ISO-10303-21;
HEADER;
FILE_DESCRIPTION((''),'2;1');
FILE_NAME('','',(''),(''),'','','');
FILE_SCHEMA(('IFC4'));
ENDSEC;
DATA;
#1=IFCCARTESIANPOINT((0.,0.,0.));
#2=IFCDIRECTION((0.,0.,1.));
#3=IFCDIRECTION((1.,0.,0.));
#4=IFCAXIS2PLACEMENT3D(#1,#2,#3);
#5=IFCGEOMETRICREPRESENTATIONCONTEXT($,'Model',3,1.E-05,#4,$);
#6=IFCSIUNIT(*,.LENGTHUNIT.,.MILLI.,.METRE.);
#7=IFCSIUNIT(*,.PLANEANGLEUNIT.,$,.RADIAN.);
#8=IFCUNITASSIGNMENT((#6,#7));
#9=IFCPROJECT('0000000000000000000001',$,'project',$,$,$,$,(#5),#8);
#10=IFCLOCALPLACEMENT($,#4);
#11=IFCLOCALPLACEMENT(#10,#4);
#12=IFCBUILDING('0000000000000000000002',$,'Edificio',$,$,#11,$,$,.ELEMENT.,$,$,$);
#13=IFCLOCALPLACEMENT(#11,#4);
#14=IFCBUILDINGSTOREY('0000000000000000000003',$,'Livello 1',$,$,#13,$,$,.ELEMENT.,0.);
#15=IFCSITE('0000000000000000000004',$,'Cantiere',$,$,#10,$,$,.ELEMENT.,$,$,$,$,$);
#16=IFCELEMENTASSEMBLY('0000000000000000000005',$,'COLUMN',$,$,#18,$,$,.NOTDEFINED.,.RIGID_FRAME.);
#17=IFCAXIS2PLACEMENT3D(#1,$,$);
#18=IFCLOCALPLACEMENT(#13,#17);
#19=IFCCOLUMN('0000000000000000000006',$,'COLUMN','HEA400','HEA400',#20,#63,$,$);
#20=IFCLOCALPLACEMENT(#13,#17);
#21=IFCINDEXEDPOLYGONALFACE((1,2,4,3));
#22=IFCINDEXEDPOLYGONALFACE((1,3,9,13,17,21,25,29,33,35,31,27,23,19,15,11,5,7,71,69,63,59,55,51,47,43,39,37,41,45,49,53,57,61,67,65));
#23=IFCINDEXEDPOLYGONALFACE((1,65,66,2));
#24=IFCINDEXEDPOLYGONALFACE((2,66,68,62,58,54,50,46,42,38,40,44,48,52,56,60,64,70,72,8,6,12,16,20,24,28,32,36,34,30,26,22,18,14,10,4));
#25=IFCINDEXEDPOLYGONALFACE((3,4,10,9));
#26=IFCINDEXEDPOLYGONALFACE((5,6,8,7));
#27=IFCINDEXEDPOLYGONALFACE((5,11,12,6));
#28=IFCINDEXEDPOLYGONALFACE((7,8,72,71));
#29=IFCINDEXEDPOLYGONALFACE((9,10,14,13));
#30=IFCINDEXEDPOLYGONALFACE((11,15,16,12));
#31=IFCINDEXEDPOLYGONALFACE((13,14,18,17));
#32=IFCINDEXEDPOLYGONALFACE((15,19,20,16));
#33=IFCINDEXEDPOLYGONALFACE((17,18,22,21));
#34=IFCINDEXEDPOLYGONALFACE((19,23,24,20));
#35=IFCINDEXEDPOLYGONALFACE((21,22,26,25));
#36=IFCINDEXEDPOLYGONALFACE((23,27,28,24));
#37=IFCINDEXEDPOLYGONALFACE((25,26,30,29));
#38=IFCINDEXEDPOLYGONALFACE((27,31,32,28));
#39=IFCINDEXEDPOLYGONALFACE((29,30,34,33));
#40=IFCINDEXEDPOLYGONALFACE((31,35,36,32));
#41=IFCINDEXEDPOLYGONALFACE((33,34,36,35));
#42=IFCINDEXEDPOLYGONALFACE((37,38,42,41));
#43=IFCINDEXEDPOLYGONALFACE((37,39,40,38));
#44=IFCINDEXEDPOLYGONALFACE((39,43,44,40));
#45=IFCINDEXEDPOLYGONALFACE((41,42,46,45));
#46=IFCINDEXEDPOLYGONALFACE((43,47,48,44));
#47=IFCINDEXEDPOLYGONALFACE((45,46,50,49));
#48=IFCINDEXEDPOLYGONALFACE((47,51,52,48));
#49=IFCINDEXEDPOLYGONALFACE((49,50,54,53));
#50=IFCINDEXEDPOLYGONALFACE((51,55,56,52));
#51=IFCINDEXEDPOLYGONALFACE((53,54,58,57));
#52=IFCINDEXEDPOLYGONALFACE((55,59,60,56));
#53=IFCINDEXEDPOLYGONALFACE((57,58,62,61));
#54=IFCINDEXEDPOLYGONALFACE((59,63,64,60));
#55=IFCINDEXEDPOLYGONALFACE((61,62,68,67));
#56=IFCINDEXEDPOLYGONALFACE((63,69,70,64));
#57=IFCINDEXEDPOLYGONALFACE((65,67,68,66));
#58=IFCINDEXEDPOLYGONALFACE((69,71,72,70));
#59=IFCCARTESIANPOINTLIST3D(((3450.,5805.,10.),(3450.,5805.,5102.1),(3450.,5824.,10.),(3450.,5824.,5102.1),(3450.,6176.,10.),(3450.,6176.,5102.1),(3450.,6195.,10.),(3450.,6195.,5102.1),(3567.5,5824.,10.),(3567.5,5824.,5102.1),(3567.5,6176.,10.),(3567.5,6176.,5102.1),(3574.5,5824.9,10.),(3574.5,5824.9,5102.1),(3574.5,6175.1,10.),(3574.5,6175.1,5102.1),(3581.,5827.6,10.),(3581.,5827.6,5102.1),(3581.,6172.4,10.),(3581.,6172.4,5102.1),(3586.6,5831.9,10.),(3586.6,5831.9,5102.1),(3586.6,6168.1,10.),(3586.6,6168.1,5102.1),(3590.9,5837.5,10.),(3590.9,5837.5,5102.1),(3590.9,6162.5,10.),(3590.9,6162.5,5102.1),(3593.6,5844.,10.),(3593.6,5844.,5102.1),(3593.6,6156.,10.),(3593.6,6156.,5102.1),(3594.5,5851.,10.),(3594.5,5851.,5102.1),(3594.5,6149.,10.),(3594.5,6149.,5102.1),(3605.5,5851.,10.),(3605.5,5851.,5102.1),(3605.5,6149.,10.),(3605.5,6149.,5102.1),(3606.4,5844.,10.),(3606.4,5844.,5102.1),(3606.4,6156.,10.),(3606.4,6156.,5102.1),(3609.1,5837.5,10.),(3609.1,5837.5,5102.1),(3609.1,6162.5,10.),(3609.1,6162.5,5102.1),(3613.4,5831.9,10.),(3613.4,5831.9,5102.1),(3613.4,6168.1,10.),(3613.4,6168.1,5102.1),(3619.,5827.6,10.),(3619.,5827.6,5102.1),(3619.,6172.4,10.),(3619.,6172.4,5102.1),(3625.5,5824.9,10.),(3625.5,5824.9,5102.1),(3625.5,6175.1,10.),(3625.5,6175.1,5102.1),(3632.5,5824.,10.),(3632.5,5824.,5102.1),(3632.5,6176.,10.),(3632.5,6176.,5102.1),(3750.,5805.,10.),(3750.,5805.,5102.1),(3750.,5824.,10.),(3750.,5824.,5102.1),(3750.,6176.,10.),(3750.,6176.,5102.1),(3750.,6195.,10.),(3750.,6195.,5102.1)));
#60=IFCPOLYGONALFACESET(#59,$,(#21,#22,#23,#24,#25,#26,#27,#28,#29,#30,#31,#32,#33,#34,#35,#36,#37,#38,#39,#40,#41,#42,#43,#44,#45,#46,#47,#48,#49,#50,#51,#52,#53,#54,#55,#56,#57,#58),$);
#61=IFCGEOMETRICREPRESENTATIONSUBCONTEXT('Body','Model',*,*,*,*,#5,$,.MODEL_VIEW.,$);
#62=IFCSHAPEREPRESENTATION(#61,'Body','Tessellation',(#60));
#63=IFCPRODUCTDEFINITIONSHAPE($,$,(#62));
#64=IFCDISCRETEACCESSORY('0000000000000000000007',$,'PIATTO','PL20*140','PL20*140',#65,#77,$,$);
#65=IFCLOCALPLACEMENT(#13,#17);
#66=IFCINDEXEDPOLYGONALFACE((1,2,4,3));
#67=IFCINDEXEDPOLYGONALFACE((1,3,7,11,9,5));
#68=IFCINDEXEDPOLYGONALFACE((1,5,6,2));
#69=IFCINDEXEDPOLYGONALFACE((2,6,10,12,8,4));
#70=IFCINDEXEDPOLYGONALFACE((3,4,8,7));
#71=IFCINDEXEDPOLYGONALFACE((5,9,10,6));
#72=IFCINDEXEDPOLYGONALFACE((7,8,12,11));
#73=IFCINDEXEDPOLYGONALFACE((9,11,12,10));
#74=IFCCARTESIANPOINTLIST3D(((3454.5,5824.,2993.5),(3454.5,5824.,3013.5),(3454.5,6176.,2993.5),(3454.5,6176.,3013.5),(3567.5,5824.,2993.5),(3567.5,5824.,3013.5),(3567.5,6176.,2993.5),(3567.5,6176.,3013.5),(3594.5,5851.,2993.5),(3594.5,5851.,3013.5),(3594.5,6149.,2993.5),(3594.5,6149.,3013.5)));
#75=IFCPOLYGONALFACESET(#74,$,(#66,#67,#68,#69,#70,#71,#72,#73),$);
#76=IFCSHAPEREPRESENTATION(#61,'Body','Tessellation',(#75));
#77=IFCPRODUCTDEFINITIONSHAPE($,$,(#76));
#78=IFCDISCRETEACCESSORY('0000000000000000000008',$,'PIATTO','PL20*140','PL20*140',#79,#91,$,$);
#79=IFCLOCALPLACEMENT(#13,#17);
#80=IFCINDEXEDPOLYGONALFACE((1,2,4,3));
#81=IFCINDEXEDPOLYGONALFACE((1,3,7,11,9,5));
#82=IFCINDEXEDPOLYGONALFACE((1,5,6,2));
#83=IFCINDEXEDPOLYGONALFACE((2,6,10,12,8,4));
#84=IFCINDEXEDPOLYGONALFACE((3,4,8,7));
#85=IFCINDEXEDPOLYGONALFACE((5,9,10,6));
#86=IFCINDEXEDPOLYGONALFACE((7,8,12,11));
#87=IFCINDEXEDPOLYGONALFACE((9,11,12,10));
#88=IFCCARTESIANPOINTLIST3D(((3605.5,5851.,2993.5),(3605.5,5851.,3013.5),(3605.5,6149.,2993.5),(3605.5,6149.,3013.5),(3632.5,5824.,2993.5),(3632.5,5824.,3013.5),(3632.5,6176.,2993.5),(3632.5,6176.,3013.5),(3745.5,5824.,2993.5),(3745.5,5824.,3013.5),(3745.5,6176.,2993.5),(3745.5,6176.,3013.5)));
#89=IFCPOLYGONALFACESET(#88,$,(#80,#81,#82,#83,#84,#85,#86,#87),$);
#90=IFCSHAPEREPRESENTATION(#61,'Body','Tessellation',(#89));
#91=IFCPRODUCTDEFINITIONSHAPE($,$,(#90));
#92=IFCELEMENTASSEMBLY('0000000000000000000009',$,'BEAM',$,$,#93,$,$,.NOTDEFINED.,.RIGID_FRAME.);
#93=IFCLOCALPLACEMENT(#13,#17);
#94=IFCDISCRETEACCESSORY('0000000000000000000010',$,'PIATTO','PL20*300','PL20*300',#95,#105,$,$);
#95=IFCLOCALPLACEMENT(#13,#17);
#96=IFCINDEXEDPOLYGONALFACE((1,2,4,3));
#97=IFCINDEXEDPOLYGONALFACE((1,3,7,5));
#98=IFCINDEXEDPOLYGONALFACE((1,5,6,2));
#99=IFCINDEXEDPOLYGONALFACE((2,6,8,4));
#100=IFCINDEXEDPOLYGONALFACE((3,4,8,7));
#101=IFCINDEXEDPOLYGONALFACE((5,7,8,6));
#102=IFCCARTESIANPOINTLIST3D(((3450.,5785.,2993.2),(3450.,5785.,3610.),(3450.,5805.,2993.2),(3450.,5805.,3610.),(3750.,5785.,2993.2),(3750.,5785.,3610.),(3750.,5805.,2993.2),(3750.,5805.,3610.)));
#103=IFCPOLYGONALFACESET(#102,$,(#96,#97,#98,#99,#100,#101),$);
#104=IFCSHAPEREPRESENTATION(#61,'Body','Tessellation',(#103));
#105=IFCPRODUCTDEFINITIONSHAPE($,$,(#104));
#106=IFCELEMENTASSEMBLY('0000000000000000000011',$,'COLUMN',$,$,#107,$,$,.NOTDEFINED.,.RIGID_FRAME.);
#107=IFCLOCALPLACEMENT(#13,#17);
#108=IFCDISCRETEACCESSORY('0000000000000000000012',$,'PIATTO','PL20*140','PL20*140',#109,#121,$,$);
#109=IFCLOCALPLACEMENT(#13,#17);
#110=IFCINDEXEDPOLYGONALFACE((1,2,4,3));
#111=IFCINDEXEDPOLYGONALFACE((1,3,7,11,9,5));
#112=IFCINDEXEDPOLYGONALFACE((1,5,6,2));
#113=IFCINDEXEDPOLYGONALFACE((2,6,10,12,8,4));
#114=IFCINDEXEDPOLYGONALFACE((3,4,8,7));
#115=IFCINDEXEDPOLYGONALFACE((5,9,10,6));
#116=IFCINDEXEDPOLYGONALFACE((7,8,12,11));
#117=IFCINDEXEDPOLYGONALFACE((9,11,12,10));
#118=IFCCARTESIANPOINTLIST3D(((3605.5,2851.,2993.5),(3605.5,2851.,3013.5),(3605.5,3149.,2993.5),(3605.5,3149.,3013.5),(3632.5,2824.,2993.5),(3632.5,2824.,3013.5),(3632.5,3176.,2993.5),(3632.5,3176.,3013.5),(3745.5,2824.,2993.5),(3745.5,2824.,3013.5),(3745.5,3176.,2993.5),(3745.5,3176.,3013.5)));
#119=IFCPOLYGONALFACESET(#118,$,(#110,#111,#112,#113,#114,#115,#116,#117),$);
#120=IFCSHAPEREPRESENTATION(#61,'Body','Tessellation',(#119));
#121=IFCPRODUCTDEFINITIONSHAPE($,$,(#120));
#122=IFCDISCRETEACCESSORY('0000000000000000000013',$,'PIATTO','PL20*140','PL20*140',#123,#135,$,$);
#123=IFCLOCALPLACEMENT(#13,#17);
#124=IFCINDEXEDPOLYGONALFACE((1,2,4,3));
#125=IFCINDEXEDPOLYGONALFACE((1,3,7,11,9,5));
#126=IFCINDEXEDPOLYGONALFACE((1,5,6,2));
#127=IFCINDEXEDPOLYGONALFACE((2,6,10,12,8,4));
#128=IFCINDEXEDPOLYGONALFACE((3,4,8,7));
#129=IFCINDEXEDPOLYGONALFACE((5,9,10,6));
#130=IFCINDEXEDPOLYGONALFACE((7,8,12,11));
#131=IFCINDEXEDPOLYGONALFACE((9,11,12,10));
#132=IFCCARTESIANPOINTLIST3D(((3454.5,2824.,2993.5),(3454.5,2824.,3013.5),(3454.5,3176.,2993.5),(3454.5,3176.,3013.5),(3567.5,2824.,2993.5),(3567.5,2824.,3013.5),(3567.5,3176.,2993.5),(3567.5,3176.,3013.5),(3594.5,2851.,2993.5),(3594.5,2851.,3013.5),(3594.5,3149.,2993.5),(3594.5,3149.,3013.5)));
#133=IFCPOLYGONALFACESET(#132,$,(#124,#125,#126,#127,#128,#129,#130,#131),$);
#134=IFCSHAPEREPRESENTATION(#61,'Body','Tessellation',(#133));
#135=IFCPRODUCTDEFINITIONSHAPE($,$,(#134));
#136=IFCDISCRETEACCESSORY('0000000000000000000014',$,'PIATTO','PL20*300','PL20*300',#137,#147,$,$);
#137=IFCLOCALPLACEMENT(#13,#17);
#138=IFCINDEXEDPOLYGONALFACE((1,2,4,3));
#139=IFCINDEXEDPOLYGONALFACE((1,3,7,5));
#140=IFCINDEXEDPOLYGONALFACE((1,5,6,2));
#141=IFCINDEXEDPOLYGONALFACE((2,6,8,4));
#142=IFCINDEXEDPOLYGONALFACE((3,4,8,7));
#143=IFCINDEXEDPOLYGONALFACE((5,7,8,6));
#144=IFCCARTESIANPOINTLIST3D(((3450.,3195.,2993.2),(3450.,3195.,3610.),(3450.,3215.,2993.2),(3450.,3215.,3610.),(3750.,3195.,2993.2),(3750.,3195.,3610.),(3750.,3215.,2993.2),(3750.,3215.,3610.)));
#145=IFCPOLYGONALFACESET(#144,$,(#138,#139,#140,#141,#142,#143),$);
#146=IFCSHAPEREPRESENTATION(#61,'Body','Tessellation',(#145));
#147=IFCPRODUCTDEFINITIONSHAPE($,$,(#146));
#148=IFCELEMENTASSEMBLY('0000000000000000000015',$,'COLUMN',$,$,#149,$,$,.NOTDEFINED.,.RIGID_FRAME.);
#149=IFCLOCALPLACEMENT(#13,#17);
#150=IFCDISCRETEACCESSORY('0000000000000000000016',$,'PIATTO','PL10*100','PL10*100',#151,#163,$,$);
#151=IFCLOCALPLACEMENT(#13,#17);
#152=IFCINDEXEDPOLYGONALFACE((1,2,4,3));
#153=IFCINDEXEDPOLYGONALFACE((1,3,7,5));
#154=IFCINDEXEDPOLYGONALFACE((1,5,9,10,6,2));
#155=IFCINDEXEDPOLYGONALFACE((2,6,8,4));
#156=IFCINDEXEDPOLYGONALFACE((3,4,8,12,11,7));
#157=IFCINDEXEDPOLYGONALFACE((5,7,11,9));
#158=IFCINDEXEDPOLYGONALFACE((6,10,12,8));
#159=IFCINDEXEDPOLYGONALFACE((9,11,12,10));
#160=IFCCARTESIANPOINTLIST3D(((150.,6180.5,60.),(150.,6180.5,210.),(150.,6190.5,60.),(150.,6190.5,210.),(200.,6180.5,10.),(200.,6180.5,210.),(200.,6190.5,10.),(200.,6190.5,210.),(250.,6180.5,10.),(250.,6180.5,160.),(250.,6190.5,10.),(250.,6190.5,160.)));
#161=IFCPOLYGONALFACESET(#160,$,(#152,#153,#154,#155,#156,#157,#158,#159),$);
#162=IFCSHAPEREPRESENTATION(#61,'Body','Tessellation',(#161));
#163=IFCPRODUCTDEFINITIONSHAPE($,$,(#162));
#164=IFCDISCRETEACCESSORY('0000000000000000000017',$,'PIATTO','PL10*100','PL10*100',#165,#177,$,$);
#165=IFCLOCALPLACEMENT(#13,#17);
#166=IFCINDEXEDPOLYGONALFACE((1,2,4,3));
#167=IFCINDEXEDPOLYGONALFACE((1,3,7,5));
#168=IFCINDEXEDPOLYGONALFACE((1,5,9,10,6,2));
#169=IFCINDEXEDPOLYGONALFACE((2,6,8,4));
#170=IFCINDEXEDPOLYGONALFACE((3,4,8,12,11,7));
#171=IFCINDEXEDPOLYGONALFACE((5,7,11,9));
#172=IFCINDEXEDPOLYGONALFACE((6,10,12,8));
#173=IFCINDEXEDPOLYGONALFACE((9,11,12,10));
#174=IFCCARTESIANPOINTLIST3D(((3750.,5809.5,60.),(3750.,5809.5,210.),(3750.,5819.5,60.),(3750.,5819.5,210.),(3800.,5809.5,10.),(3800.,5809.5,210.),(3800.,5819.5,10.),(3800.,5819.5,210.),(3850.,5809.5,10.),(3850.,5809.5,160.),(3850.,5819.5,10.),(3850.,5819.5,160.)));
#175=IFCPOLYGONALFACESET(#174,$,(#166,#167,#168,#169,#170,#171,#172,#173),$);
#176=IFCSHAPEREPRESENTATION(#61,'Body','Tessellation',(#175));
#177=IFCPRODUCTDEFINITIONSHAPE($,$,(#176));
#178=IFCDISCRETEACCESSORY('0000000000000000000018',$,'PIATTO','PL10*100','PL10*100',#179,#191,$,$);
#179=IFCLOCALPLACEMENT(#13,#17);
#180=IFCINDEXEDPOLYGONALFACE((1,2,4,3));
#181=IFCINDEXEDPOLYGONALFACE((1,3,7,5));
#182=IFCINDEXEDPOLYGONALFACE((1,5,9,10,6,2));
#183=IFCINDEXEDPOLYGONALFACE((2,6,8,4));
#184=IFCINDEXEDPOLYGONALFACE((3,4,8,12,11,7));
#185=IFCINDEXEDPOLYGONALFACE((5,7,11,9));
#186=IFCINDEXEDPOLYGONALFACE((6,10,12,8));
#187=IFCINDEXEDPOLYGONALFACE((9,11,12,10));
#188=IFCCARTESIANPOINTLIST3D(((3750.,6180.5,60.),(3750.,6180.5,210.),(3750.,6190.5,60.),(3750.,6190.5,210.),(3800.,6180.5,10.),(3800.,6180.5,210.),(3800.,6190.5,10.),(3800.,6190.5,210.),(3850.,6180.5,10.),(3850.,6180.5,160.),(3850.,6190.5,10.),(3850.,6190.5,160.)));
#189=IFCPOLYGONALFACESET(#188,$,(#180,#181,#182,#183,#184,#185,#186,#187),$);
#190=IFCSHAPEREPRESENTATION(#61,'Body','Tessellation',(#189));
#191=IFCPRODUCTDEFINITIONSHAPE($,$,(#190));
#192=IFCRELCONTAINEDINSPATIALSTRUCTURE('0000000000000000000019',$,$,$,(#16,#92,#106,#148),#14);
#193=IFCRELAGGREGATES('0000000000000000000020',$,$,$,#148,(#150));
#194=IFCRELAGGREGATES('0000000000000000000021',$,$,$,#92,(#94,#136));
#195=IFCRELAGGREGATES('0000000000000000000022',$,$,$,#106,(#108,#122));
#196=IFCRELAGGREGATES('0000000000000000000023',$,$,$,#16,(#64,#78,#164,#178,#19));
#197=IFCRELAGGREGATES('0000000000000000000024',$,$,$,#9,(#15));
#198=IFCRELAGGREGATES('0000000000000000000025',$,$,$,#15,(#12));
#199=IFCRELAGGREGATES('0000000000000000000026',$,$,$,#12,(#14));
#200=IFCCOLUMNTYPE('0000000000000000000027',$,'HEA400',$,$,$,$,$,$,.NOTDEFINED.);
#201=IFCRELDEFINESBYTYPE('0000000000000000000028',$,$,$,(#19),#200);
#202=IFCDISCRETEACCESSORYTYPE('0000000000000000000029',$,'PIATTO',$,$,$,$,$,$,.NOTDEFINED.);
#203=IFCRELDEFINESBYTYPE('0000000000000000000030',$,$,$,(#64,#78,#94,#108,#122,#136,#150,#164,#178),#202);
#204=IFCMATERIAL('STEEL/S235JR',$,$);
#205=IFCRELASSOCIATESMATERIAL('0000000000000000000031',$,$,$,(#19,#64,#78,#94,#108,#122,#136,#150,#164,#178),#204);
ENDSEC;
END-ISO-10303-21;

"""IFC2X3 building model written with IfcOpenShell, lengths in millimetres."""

from ifc_helpers import new_model, si_unit, frame, origin_with_axes, origin_2d_with_axis, place, context, subcontext, project, spatial, polyline, i_section, outline, extrude, clip, halfspace, material, type_object, element, aggregate, save


model = new_model("IFC2X3")

# Units and contexts
model_context = context("Model", 3, precision=1e-05, world=origin_with_axes())
body_context = subcontext(model_context, "Body", "Model", "MODEL_VIEW")
ifc_project = project(units=[si_unit("LENGTHUNIT", "METRE", prefix="MILLI"), si_unit("PLANEANGLEUNIT", "RADIAN")], contexts=[model_context])

# Site, building, storey
site_placement = place(None, origin_with_axes())
site = spatial("IfcSite", under=ifc_project, at=site_placement, Name="Cantiere", CompositionType="ELEMENT")
building_placement = place(site_placement, origin_with_axes())
building = spatial("IfcBuilding", under=site, at=building_placement, Name="Edificio", CompositionType="ELEMENT")
storey_placement = place(building_placement, origin_with_axes())
storey = spatial("IfcBuildingStorey", under=building, at=storey_placement, Name="Livello 1", CompositionType="ELEMENT", Elevation=0.0)

# Element assembly, column, discrete accessories
assembly_1_placement = place(storey_placement, origin_with_axes())
assembly_1 = element("IfcElementAssembly", 1, at=assembly_1_placement, inside=storey, Name="COLUMN", AssemblyPlace="NOTDEFINED", PredefinedType="RIGID_FRAME")
ifc_material_1 = material(Name="STEEL/S235JR")
column_type = type_object("IfcColumnType", Name="HEA400", PredefinedType="NOTDEFINED")
column_placement = place(assembly_1_placement, frame((3600.0, 6000.0, 0.0), z_axis=(0.0, 0.0, 1.0), x_axis=(0.0, 1.0, 0.0)))
column = element("IfcColumn", 2, at=column_placement, type_object=column_type, material=ifc_material_1, Name="COLUMN", Description="HEA400", ObjectType="HEA400", context=body_context, shape_type="Clipping", body=[
    clip(clip(extrude(i_section(OverallWidth=300.0, OverallDepth=390.0, WebThickness=11.0, FlangeThickness=19.0, FilletRadius=27.0, at=origin_2d_with_axis()), frame((0.0, 0.0, 5102.1), z_axis=(0.0, 0.0, -1.0), x_axis=(0.0, 1.0, 0.0)), (0.0, 0.0, 1.0), 5092.1), halfspace(frame((-1000.0, 0.0, 5102.1), z_axis=(0.0, 0.0, 1.0), x_axis=(0.0, 1.0, 0.0)), False)), halfspace(frame((-195.0, 0.0, 10.0), z_axis=(0.0, 0.0, 1.0), x_axis=(0.0, 1.0, 0.0)), True)),
])
discrete_accessory_type_1 = type_object("IfcDiscreteAccessoryType", Name="PIATTO")
discrete_accessory_1_placement = place(assembly_1_placement, frame((3454.5, 5824.0, 3003.5), z_axis=(0.0, 0.0, 1.0), x_axis=(1.0, 0.0, 0.0)))
discrete_accessory_1 = element("IfcDiscreteAccessory", 3, at=discrete_accessory_1_placement, type_object=discrete_accessory_type_1, material=ifc_material_1, Name="PIATTO", Description="PL20*140", ObjectType="PL20*140", context=body_context, shape_type="SweptSolid", body=[
    extrude(outline(polyline([(0.0, 0.0), (113.0, 0.0), (140.0, 27.0), (140.0, 325.0), (113.0, 352.0), (0.0, 352.0), (0.0, 0.0)])), frame((0.0, 0.0, -10.0), z_axis=(0.0, 0.0, 1.0), x_axis=(1.0, 0.0, 0.0)), (0.0, 0.0, 1.0), 20.0),
])
discrete_accessory_2_placement = place(assembly_1_placement, frame((3745.5, 5824.0, 3003.5), z_axis=(0.0, 0.0, -1.0), x_axis=(-1.0, 0.0, 0.0)))
discrete_accessory_2 = element("IfcDiscreteAccessory", 4, at=discrete_accessory_2_placement, type_object=discrete_accessory_type_1, material=ifc_material_1, Name="PIATTO", Description="PL20*140", ObjectType="PL20*140", context=body_context, shape_type="SweptSolid", body=[
    extrude(outline(polyline([(0.0, 0.0), (113.0, 0.0), (140.0, 27.0), (140.0, 325.0), (113.0, 352.0), (0.0, 352.0), (0.0, 0.0)])), frame((0.0, 0.0, -10.0), z_axis=(0.0, 0.0, 1.0), x_axis=(1.0, 0.0, 0.0)), (0.0, 0.0, 1.0), 20.0),
])

# Element assembly, discrete accessory
assembly_2_placement = place(storey_placement, origin_with_axes())
assembly_2 = element("IfcElementAssembly", 5, at=assembly_2_placement, inside=storey, Name="BEAM", AssemblyPlace="NOTDEFINED", PredefinedType="RIGID_FRAME")
discrete_accessory_3_placement = place(assembly_2_placement, frame((3600.0, 5795.0, 2993.2), z_axis=(0.0, -1.0, 0.0), x_axis=(0.0, 0.0, 1.0)))
discrete_accessory_3 = element("IfcDiscreteAccessory", 6, at=discrete_accessory_3_placement, type_object=discrete_accessory_type_1, material=ifc_material_1, Name="PIATTO", Description="PL20*300", ObjectType="PL20*300", context=body_context, shape_type="SweptSolid", body=[
    extrude(outline(polyline([(0.0, 150.0), (616.8, 150.0), (616.8, -150.0), (0.0, -150.0), (0.0, 150.0)])), frame((0.0, 0.0, -10.0), z_axis=(0.0, 0.0, 1.0), x_axis=(1.0, 0.0, 0.0)), (0.0, 0.0, 1.0), 20.0),
])

# Element assembly, discrete accessories
assembly_3_placement = place(storey_placement, origin_with_axes())
assembly_3 = element("IfcElementAssembly", 7, at=assembly_3_placement, inside=storey, Name="COLUMN", AssemblyPlace="NOTDEFINED", PredefinedType="RIGID_FRAME")
discrete_accessory_4_placement = place(assembly_3_placement, frame((3745.5, 3176.0, 3003.5), z_axis=(0.0, 0.0, 1.0), x_axis=(-1.0, 0.0, 0.0)))
discrete_accessory_4 = element("IfcDiscreteAccessory", 8, at=discrete_accessory_4_placement, type_object=discrete_accessory_type_1, material=ifc_material_1, Name="PIATTO", Description="PL20*140", ObjectType="PL20*140", context=body_context, shape_type="SweptSolid", body=[
    extrude(outline(polyline([(0.0, 0.0), (113.0, 0.0), (140.0, 27.0), (140.0, 325.0), (113.0, 352.0), (0.0, 352.0), (0.0, 0.0)])), frame((0.0, 0.0, -10.0), z_axis=(0.0, 0.0, 1.0), x_axis=(1.0, 0.0, 0.0)), (0.0, 0.0, 1.0), 20.0),
])
discrete_accessory_5_placement = place(assembly_3_placement, frame((3454.5, 3176.0, 3003.5), z_axis=(0.0, 0.0, -1.0), x_axis=(1.0, 0.0, 0.0)))
discrete_accessory_5 = element("IfcDiscreteAccessory", 9, at=discrete_accessory_5_placement, type_object=discrete_accessory_type_1, material=ifc_material_1, Name="PIATTO", Description="PL20*140", ObjectType="PL20*140", context=body_context, shape_type="SweptSolid", body=[
    extrude(outline(polyline([(0.0, 0.0), (113.0, 0.0), (140.0, 27.0), (140.0, 325.0), (113.0, 352.0), (0.0, 352.0), (0.0, 0.0)])), frame((0.0, 0.0, -10.0), z_axis=(0.0, 0.0, 1.0), x_axis=(1.0, 0.0, 0.0)), (0.0, 0.0, 1.0), 20.0),
])

# Discrete accessory
discrete_accessory_6_placement = place(assembly_2_placement, frame((3600.0, 3205.0, 2993.2), z_axis=(0.0, 1.0, 0.0), x_axis=(0.0, 0.0, 1.0)))
discrete_accessory_6 = element("IfcDiscreteAccessory", 10, at=discrete_accessory_6_placement, type_object=discrete_accessory_type_1, material=ifc_material_1, Name="PIATTO", Description="PL20*300", ObjectType="PL20*300", context=body_context, shape_type="SweptSolid", body=[
    extrude(outline(polyline([(0.0, -150.0), (0.0, 150.0), (616.8, 150.0), (616.8, -150.0), (0.0, -150.0)])), frame((0.0, 0.0, -10.0), z_axis=(0.0, 0.0, 1.0), x_axis=(1.0, 0.0, 0.0)), (0.0, 0.0, 1.0), 20.0),
])

# Element assembly, discrete accessory
assembly_4_placement = place(storey_placement, origin_with_axes())
assembly_4 = element("IfcElementAssembly", 11, at=assembly_4_placement, inside=storey, Name="COLUMN", AssemblyPlace="NOTDEFINED", PredefinedType="RIGID_FRAME")
discrete_accessory_7_placement = place(assembly_4_placement, frame((150.0, 6185.5, 60.0), z_axis=(0.0, -1.0, 0.0), x_axis=(0.707107, 0.0, -0.707107)))
discrete_accessory_7 = element("IfcDiscreteAccessory", 12, at=discrete_accessory_7_placement, type_object=discrete_accessory_type_1, material=ifc_material_1, Name="PIATTO", Description="PL10*100", ObjectType="PL10*100", context=body_context, shape_type="SweptSolid", body=[
    extrude(outline(polyline([(0.0, 0.0), (70.7, 0.0), (106.1, 35.4), (0.0, 141.4), (-70.7, 141.4), (-106.1, 106.1), (0.0, 0.0)])), frame((0.0, 0.0, -5.0), z_axis=(0.0, 0.0, 1.0), x_axis=(1.0, 0.0, 0.0)), (0.0, 0.0, 1.0), 10.0),
])
aggregate(assembly_4, [discrete_accessory_7])

# Discrete accessories
discrete_accessory_8_placement = place(assembly_1_placement, frame((3750.0, 5814.5, 60.0), z_axis=(0.0, -1.0, 0.0), x_axis=(0.707107, 0.0, -0.707107)))
discrete_accessory_8 = element("IfcDiscreteAccessory", 13, at=discrete_accessory_8_placement, type_object=discrete_accessory_type_1, material=ifc_material_1, Name="PIATTO", Description="PL10*100", ObjectType="PL10*100", context=body_context, shape_type="SweptSolid", body=[
    extrude(outline(polyline([(0.0, 0.0), (70.7, 0.0), (106.1, 35.4), (0.0, 141.4), (-70.7, 141.4), (-106.1, 106.1), (0.0, 0.0)])), frame((0.0, 0.0, -5.0), z_axis=(0.0, 0.0, 1.0), x_axis=(1.0, 0.0, 0.0)), (0.0, 0.0, 1.0), 10.0),
])
discrete_accessory_9_placement = place(assembly_1_placement, frame((3750.0, 6185.5, 60.0), z_axis=(0.0, -1.0, 0.0), x_axis=(0.707107, 0.0, -0.707107)))
discrete_accessory_9 = element("IfcDiscreteAccessory", 14, at=discrete_accessory_9_placement, type_object=discrete_accessory_type_1, material=ifc_material_1, Name="PIATTO", Description="PL10*100", ObjectType="PL10*100", context=body_context, shape_type="SweptSolid", body=[
    extrude(outline(polyline([(0.0, 0.0), (70.7, 0.0), (106.1, 35.4), (0.0, 141.4), (-70.7, 141.4), (-106.1, 106.1), (0.0, 0.0)])), frame((0.0, 0.0, -5.0), z_axis=(0.0, 0.0, 1.0), x_axis=(1.0, 0.0, 0.0)), (0.0, 0.0, 1.0), 10.0),
])

aggregate(assembly_2, [discrete_accessory_3, discrete_accessory_6])
aggregate(assembly_3, [discrete_accessory_4, discrete_accessory_5])

aggregate(assembly_1, [discrete_accessory_1, discrete_accessory_2, discrete_accessory_8, discrete_accessory_9, column])

save(model, "model.ifc")
